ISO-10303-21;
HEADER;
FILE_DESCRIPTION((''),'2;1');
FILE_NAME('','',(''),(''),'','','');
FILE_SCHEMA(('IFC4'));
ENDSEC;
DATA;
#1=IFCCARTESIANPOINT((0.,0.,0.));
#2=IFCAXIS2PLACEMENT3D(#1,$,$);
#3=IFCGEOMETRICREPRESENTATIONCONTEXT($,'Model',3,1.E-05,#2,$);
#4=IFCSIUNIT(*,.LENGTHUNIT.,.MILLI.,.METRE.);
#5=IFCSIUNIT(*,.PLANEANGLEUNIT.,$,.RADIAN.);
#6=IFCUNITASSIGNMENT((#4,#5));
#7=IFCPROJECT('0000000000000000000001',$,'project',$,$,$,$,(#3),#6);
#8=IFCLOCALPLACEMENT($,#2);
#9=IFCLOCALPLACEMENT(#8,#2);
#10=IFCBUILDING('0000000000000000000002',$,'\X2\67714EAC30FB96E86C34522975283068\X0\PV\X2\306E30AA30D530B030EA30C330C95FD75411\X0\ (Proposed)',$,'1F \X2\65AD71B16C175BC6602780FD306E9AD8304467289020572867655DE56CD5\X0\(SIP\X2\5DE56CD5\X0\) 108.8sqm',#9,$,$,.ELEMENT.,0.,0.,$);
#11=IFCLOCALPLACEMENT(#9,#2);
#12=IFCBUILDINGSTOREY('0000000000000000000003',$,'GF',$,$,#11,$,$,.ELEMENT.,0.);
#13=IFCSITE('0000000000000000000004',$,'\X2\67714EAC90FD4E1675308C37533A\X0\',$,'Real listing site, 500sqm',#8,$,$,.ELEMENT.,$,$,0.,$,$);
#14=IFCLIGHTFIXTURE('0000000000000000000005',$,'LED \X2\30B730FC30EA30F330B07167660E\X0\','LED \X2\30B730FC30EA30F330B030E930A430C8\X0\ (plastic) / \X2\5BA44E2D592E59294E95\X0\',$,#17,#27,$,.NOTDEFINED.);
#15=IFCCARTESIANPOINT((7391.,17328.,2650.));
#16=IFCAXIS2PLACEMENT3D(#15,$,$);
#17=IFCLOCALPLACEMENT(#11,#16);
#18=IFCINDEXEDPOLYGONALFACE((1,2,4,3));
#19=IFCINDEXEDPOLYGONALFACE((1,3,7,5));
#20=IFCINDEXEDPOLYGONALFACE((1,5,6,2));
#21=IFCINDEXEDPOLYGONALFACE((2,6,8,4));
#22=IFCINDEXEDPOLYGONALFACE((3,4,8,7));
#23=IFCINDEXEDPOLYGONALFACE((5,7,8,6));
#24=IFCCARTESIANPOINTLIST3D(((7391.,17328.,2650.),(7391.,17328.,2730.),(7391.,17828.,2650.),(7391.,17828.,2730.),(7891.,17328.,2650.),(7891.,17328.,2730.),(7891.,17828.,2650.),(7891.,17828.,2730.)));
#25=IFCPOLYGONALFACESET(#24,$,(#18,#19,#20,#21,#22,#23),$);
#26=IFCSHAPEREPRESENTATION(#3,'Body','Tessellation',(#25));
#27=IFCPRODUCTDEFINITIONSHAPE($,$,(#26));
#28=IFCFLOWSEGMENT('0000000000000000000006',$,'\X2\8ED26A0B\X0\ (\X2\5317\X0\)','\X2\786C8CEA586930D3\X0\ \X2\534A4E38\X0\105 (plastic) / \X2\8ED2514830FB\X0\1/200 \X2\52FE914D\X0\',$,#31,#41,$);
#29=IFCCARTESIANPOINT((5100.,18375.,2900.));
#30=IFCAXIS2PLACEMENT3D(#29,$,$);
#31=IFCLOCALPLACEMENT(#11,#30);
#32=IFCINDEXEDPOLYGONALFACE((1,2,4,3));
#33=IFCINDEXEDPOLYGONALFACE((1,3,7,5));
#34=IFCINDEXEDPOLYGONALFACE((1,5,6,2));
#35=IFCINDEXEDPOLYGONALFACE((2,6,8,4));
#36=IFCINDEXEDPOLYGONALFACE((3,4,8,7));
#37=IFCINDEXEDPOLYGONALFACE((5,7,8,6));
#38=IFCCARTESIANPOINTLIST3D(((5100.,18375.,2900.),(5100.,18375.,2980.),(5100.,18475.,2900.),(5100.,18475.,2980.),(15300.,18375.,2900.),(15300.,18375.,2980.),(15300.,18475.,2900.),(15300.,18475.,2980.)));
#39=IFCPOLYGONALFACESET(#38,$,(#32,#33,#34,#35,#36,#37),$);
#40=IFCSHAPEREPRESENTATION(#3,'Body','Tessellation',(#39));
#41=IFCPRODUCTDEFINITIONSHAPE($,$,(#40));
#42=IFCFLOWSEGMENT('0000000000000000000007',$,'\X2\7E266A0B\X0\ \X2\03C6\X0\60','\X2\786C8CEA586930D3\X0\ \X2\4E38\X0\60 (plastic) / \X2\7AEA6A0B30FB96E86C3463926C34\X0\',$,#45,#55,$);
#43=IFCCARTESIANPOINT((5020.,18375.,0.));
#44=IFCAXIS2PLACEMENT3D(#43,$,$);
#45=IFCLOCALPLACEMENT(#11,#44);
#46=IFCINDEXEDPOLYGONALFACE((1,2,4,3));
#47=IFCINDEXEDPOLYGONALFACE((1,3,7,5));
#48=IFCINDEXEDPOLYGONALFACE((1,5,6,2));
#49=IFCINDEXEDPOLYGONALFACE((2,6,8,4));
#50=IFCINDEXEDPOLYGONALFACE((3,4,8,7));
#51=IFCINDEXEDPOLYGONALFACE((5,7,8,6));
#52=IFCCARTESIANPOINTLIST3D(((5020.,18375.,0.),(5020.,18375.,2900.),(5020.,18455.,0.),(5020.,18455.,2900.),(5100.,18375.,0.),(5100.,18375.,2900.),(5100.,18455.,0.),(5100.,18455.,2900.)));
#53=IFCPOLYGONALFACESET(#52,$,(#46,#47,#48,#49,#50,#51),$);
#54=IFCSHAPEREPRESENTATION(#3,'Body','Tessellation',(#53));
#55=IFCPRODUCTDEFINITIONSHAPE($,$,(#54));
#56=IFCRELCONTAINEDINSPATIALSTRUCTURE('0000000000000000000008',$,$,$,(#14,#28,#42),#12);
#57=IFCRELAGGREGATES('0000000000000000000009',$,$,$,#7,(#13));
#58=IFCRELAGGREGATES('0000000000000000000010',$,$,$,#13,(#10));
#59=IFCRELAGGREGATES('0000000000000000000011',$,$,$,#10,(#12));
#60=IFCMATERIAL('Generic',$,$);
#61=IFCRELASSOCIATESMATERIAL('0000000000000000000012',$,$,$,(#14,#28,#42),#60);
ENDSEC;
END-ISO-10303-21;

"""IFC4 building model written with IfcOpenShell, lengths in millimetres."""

from ifc_helpers import new_model, si_unit, frame, frame_2d, origin, place, context, project, spatial, rectangle, extrude, material, element, save


model = new_model("IFC4")

# Units and contexts
model_context = context("Model", 3, precision=1e-05, world=origin())
ifc_project = project(units=[si_unit("LENGTHUNIT", "METRE", prefix="MILLI"), si_unit("PLANEANGLEUNIT", "RADIAN")], contexts=[model_context])

# Site, building, storey
site_placement = place(None, origin())
site = spatial("IfcSite", under=ifc_project, at=site_placement, Name="東京都世田谷区", ObjectType="Real listing site, 500sqm", CompositionType="ELEMENT", RefElevation=0.0)
building_placement = place(site_placement, origin())
building = spatial("IfcBuilding", under=site, at=building_placement, Name="東京・雨水利用とPVのオフグリッド志向 (Proposed)", ObjectType="1F 断熱気密性能の高い木造在来工法(SIP工法) 108.8sqm", CompositionType="ELEMENT", ElevationOfRefHeight=0.0, ElevationOfTerrain=0.0)
storey_placement = place(building_placement, origin())
storey = spatial("IfcBuildingStorey", under=building, at=storey_placement, Name="GF", CompositionType="ELEMENT", Elevation=0.0)

# Shared definitions
ifc_material_1 = material(Name="Generic")

# Light fixture
light_fixture_placement = place(storey_placement, frame((7391.0, 17328.0, 2650.0)))
element("IfcLightFixture", 1, at=light_fixture_placement, inside=storey, material=ifc_material_1, Name="LED シーリング照明", Description="LED シーリングライト (plastic) / 室中央天井", PredefinedType="NOTDEFINED", context=model_context, shape_type="SweptSolid", body=[
    extrude(rectangle(XDim=500.0, YDim=500.0, at=frame_2d((250.0, 250.0))), frame((7391.0, 17328.0, 2650.0)), (0.0, 0.0, 1.0), 80.0),
])

# Flow segments
flow_segment_1_placement = place(storey_placement, frame((5100.0, 18375.0, 2900.0)))
element("IfcFlowSegment", 2, at=flow_segment_1_placement, inside=storey, material=ifc_material_1, Name="軒樋 (北)", Description="硬質塩ビ 半丸105 (plastic) / 軒先・1/200 勾配", context=model_context, shape_type="SweptSolid", body=[
    extrude(rectangle(XDim=10200.0, YDim=100.0, at=frame_2d((5100.0, 50.0))), frame((5100.0, 18375.0, 2900.0)), (0.0, 0.0, 1.0), 80.0),
])
flow_segment_2_placement = place(storey_placement, frame((5020.0, 18375.0, 0.0)))
element("IfcFlowSegment", 3, at=flow_segment_2_placement, inside=storey, material=ifc_material_1, Name="縦樋 φ60", Description="硬質塩ビ 丸60 (plastic) / 竪樋・雨水排水", context=model_context, shape_type="SweptSolid", body=[
    extrude(rectangle(XDim=80.0, YDim=80.0, at=frame_2d((40.0, 40.0))), frame((5020.0, 18375.0, 0.0)), (0.0, 0.0, 1.0), 2900.0),
])

save(model, "model.ifc")
